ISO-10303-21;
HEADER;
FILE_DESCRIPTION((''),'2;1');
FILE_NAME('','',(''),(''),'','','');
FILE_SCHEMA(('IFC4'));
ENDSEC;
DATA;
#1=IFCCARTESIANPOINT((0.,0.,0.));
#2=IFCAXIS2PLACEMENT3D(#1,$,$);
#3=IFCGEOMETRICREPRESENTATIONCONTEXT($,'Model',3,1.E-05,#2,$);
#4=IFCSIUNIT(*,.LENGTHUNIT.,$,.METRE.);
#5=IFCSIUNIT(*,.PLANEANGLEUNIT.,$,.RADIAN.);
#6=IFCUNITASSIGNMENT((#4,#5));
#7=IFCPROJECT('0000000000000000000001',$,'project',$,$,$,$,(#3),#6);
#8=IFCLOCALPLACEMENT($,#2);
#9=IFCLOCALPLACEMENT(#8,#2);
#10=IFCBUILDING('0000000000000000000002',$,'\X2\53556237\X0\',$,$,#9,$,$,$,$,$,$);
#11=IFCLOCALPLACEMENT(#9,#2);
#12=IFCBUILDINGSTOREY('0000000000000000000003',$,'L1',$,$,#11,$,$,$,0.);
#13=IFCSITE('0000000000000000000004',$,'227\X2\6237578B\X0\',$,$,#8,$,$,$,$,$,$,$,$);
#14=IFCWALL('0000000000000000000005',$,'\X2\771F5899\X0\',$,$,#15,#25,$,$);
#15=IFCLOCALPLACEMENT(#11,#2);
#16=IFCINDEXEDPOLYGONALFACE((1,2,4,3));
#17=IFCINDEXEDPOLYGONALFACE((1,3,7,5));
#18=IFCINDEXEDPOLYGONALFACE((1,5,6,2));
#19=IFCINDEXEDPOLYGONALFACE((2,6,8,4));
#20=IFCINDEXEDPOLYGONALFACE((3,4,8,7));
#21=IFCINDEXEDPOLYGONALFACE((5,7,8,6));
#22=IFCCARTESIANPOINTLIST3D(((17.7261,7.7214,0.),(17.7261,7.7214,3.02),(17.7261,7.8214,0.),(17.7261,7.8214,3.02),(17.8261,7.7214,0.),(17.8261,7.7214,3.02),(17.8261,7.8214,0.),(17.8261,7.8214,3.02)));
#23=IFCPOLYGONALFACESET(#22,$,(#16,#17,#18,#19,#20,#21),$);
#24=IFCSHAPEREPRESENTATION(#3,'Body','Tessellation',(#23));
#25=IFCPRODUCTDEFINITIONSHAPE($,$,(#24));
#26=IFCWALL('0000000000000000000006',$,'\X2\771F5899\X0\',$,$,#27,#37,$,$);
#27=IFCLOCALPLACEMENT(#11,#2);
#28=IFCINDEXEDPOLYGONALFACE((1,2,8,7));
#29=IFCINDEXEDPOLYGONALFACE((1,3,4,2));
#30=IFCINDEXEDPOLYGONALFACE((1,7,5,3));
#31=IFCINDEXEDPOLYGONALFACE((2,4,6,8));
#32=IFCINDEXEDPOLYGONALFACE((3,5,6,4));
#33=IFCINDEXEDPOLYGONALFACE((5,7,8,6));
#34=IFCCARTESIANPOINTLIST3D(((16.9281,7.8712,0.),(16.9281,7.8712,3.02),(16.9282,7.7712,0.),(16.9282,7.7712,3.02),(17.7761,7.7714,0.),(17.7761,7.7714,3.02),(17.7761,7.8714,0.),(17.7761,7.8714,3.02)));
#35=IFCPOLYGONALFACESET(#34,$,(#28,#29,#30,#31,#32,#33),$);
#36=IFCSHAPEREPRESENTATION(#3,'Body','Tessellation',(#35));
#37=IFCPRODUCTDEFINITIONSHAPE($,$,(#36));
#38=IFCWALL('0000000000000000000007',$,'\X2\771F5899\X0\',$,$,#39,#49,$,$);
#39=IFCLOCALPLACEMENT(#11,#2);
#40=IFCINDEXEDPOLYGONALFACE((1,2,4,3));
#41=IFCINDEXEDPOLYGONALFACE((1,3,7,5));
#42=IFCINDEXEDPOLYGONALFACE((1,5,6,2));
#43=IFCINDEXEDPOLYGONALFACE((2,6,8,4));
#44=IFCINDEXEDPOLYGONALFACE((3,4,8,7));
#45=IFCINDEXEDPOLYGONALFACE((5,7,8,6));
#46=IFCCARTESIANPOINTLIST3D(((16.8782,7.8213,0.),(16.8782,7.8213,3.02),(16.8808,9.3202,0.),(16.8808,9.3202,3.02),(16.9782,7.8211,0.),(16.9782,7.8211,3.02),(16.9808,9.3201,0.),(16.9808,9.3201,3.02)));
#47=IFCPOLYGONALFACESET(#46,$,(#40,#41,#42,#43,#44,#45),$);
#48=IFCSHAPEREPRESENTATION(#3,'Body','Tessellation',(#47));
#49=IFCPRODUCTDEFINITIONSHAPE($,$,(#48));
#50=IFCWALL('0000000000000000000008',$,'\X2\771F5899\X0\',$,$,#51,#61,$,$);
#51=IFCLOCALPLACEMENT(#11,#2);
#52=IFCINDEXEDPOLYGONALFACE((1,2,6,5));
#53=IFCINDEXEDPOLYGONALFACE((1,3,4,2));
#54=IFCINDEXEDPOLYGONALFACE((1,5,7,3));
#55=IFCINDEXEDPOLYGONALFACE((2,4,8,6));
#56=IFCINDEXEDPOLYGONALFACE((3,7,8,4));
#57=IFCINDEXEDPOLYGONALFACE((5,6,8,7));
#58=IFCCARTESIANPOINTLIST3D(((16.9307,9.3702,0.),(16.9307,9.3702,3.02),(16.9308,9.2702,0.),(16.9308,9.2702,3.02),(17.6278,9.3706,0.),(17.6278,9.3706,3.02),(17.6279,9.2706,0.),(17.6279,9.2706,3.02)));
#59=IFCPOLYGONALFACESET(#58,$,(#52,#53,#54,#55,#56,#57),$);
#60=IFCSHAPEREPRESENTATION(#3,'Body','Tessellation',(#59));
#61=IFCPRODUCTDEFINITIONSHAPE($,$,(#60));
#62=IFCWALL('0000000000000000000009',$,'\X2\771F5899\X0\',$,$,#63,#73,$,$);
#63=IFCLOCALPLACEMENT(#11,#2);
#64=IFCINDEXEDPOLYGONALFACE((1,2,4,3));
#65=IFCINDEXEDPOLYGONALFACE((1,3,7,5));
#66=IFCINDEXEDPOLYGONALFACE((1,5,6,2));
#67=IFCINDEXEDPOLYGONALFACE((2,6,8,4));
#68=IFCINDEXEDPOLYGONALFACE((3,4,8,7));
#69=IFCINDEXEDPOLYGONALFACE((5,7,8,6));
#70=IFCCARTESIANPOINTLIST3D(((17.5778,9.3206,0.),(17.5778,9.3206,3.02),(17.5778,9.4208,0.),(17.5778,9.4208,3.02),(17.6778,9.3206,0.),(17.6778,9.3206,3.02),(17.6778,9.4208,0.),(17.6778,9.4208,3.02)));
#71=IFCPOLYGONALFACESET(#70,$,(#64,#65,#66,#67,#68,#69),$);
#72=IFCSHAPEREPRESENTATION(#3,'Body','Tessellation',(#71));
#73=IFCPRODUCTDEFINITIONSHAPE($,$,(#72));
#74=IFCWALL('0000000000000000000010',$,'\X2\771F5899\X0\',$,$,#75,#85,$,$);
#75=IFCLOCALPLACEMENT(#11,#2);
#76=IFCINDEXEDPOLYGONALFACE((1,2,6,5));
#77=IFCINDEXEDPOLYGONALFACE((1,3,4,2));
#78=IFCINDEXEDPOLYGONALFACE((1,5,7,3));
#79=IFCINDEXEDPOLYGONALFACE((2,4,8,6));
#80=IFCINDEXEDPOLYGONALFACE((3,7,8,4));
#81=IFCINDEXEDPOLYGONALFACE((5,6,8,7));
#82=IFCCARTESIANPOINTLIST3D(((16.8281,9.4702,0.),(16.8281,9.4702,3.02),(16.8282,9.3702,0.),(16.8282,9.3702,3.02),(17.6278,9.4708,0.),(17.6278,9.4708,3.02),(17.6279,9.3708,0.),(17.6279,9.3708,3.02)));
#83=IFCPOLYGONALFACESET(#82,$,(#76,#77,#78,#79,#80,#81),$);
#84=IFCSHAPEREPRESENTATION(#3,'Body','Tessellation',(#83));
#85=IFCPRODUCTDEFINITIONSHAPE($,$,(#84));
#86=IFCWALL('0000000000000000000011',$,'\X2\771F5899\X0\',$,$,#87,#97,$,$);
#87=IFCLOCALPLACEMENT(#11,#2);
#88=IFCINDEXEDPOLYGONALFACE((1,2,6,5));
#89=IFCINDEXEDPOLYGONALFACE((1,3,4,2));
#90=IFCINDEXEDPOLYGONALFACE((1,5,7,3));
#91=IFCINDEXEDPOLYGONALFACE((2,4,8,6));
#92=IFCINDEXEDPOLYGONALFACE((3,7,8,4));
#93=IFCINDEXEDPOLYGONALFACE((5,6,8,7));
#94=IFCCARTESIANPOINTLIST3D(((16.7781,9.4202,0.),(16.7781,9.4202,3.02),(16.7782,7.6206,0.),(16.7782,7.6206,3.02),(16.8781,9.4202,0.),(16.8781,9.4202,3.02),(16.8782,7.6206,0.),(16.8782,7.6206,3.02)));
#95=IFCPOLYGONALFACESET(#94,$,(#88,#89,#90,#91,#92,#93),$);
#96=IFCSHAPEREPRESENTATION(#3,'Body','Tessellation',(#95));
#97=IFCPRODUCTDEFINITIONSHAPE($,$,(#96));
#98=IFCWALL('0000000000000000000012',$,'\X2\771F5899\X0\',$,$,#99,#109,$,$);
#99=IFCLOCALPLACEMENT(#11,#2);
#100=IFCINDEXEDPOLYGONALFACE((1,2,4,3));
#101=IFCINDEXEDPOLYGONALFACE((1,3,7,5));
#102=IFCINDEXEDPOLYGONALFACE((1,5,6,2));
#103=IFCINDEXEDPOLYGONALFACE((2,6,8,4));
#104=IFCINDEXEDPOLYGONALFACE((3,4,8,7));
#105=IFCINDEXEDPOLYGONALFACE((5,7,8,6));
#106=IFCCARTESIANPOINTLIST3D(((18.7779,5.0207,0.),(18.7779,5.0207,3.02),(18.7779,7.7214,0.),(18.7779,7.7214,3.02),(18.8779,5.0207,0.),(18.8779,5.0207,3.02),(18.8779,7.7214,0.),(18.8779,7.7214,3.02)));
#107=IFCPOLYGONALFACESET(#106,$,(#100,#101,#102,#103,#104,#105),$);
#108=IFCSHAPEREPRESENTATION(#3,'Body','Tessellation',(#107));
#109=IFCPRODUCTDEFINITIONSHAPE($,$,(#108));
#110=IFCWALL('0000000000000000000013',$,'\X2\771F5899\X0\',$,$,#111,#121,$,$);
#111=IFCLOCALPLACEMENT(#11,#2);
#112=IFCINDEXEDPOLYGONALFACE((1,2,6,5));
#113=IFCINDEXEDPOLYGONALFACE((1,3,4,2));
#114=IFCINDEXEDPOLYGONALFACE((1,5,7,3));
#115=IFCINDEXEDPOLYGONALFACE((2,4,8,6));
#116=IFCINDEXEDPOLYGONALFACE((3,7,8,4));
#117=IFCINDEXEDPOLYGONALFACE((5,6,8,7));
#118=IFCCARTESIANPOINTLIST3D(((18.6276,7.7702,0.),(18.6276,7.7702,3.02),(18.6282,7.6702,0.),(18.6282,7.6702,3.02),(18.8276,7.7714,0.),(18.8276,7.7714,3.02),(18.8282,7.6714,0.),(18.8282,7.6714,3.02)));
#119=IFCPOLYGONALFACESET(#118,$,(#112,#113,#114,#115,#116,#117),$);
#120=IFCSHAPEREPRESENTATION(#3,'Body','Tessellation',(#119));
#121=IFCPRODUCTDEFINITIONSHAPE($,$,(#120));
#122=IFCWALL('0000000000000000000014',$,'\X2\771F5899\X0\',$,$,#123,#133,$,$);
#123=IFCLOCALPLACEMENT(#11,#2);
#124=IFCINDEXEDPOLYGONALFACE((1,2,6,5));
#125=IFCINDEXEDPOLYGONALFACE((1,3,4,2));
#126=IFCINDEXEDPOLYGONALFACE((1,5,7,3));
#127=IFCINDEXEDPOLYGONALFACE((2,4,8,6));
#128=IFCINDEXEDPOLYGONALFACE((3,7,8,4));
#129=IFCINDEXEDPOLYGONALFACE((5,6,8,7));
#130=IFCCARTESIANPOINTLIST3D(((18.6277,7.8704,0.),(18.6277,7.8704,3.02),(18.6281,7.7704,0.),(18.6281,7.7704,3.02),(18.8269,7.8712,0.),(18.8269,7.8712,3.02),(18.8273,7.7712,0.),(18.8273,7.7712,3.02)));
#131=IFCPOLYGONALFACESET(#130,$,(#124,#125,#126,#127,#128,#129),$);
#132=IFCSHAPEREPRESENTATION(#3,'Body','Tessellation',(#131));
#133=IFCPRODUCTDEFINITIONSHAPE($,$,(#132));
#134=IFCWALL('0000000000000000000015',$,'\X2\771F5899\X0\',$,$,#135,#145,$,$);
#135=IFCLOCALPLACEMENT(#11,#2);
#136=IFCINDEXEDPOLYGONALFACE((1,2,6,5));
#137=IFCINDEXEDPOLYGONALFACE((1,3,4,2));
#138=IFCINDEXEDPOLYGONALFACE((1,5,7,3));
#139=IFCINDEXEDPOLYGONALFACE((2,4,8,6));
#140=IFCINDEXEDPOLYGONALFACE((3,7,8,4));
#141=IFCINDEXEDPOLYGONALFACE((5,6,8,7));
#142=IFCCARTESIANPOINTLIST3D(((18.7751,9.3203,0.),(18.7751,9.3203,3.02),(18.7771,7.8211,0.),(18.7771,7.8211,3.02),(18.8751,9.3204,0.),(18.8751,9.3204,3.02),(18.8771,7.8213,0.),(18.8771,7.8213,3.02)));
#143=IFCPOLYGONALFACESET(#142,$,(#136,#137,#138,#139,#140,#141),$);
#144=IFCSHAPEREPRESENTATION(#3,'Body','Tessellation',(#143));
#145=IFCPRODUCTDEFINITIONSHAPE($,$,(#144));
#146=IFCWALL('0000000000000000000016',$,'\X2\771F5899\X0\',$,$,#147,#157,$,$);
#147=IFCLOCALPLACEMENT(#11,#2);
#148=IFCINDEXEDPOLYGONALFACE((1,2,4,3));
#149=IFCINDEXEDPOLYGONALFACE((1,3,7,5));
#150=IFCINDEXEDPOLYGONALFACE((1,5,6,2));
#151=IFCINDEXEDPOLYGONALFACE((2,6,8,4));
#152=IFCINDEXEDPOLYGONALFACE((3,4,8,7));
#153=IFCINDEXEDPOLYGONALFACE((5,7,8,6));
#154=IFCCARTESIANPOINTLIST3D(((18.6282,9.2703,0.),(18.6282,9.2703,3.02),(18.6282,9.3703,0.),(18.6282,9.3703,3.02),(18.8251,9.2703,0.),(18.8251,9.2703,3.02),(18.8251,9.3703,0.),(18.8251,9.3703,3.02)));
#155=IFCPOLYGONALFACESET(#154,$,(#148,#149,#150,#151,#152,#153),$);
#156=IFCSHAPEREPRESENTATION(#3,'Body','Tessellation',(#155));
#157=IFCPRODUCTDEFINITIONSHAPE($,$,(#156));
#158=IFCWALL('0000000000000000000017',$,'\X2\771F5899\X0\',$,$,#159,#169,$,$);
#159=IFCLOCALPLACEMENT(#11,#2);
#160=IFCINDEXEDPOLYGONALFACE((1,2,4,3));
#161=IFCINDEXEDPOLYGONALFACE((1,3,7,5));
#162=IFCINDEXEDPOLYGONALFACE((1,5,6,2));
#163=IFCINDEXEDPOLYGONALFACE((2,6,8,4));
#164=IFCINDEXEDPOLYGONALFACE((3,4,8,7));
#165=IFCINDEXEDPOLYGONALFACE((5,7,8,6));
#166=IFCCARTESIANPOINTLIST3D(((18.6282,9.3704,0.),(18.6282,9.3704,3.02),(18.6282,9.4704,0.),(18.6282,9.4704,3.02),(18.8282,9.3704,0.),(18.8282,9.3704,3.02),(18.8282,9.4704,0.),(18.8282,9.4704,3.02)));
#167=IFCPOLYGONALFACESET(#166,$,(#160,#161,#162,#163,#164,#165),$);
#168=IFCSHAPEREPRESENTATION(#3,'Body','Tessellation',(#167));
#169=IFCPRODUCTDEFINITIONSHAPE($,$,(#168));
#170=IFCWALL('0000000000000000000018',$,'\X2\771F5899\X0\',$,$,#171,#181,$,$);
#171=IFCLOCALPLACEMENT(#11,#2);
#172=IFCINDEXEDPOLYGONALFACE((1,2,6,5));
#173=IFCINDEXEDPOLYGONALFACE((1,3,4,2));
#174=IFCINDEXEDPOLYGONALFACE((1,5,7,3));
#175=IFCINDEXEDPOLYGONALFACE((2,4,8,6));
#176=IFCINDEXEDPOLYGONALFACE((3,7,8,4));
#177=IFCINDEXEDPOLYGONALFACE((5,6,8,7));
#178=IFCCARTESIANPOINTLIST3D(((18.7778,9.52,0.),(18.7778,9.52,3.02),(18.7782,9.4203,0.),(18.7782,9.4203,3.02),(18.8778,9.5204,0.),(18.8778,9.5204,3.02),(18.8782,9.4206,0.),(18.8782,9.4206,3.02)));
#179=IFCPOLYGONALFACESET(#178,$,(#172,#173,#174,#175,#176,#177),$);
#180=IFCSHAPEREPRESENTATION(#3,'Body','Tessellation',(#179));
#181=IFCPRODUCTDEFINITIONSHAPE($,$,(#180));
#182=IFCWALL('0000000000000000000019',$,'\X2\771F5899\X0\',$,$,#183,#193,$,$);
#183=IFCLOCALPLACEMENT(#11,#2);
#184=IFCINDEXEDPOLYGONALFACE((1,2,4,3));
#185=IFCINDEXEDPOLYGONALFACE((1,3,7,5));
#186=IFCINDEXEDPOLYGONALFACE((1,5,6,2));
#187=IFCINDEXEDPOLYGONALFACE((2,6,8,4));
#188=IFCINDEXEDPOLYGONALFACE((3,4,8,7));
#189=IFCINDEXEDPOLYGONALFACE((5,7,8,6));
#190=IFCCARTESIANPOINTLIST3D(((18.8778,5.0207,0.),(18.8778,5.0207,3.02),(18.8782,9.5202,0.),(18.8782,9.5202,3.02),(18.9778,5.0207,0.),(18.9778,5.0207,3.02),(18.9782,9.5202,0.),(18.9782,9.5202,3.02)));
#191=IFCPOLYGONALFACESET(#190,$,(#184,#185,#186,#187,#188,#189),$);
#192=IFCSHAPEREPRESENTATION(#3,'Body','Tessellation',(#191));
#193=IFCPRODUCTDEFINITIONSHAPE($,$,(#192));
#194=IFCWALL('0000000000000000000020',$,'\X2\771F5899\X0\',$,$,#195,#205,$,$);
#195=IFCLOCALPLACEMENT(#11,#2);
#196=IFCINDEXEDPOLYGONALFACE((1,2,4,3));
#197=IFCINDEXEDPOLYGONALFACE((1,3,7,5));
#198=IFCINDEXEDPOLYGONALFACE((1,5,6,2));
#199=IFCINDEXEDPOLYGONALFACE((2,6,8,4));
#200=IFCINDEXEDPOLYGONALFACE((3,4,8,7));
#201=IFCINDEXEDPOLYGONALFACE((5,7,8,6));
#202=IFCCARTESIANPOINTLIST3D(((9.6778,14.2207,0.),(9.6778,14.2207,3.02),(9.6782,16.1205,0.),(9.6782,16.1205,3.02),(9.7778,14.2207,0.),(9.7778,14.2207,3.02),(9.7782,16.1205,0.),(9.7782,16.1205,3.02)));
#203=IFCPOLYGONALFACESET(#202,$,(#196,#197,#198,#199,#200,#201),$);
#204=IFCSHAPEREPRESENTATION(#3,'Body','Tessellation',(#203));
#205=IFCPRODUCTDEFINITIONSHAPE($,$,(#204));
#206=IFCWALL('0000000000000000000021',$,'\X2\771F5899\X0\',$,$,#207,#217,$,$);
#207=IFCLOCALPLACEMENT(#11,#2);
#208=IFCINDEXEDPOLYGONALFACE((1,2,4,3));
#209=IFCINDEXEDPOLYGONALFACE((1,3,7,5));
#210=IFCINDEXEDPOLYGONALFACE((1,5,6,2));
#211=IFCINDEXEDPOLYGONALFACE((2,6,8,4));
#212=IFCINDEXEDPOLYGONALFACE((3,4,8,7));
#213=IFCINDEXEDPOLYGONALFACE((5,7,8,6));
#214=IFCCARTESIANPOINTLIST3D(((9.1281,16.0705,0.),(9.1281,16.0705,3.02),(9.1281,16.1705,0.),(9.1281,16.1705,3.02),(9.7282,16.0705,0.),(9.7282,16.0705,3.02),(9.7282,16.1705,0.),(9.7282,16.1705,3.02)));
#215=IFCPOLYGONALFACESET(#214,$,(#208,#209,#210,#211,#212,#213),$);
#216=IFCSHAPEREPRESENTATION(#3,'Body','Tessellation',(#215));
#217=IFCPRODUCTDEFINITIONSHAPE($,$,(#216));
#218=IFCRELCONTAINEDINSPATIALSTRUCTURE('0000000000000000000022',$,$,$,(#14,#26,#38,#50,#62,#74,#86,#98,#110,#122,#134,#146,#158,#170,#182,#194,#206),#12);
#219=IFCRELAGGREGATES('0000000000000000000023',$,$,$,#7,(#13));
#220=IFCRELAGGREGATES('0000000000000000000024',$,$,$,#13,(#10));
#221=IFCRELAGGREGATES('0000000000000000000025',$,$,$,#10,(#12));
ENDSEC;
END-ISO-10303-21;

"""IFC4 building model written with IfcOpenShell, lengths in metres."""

from ifc_helpers import new_model, si_unit, origin, place, context, project, spatial, polyline, outline, extrude, element, save


model = new_model("IFC4")

# Units and contexts
model_context = context("Model", 3, precision=1e-05, world=origin())
ifc_project = project(units=[si_unit("LENGTHUNIT", "METRE"), si_unit("PLANEANGLEUNIT", "RADIAN")], contexts=[model_context])

# Site, building, storey
site_placement = place(None, origin())
site = spatial("IfcSite", under=ifc_project, at=site_placement, Name="227户型")
building_placement = place(site_placement, origin())
building = spatial("IfcBuilding", under=site, at=building_placement, Name="单户")
storey_placement = place(building_placement, origin())
storey = spatial("IfcBuildingStorey", under=building, at=storey_placement, Name="L1", Elevation=0.0)

# Walls
wall_1_placement = place(storey_placement, origin())
element("IfcWall", 1, at=wall_1_placement, inside=storey, Name="真墙", context=model_context, shape_type="SweptSolid", body=[
    extrude(outline(polyline([(17.7261, 7.7214), (17.7261, 7.8214), (17.8261, 7.8214), (17.8261, 7.7214), (17.7261, 7.7214)])), origin(), (0.0, 0.0, 1.0), 3.02),
])
wall_2_placement = place(storey_placement, origin())
element("IfcWall", 2, at=wall_2_placement, inside=storey, Name="真墙", context=model_context, shape_type="SweptSolid", body=[
    extrude(outline(polyline([(17.7761, 7.7714), (16.9282, 7.7712), (16.9281, 7.8712), (17.7761, 7.8714), (17.7761, 7.7714)])), origin(), (0.0, 0.0, 1.0), 3.02),
])
wall_3_placement = place(storey_placement, origin())
element("IfcWall", 3, at=wall_3_placement, inside=storey, Name="真墙", context=model_context, shape_type="SweptSolid", body=[
    extrude(outline(polyline([(16.8782, 7.8213), (16.8808, 9.3202), (16.9808, 9.3201), (16.9782, 7.8211), (16.8782, 7.8213)])), origin(), (0.0, 0.0, 1.0), 3.02),
])
wall_4_placement = place(storey_placement, origin())
element("IfcWall", 4, at=wall_4_placement, inside=storey, Name="真墙", context=model_context, shape_type="SweptSolid", body=[
    extrude(outline(polyline([(16.9307, 9.3702), (17.6278, 9.3706), (17.6279, 9.2706), (16.9308, 9.2702), (16.9307, 9.3702)])), origin(), (0.0, 0.0, 1.0), 3.02),
])
wall_5_placement = place(storey_placement, origin())
element("IfcWall", 5, at=wall_5_placement, inside=storey, Name="真墙", context=model_context, shape_type="SweptSolid", body=[
    extrude(outline(polyline([(17.5778, 9.3206), (17.5778, 9.4208), (17.6778, 9.4208), (17.6778, 9.3206), (17.5778, 9.3206)])), origin(), (0.0, 0.0, 1.0), 3.02),
])
wall_6_placement = place(storey_placement, origin())
element("IfcWall", 6, at=wall_6_placement, inside=storey, Name="真墙", context=model_context, shape_type="SweptSolid", body=[
    extrude(outline(polyline([(17.6279, 9.3708), (16.8282, 9.3702), (16.8281, 9.4702), (17.6278, 9.4708), (17.6279, 9.3708)])), origin(), (0.0, 0.0, 1.0), 3.02),
])
wall_7_placement = place(storey_placement, origin())
element("IfcWall", 7, at=wall_7_placement, inside=storey, Name="真墙", context=model_context, shape_type="SweptSolid", body=[
    extrude(outline(polyline([(16.8781, 9.4202), (16.8782, 7.6206), (16.7782, 7.6206), (16.7781, 9.4202), (16.8781, 9.4202)])), origin(), (0.0, 0.0, 1.0), 3.02),
])
wall_8_placement = place(storey_placement, origin())
element("IfcWall", 8, at=wall_8_placement, inside=storey, Name="真墙", context=model_context, shape_type="SweptSolid", body=[
    extrude(outline(polyline([(18.7779, 5.0207), (18.7779, 7.7214), (18.8779, 7.7214), (18.8779, 5.0207), (18.7779, 5.0207)])), origin(), (0.0, 0.0, 1.0), 3.02),
])
wall_9_placement = place(storey_placement, origin())
element("IfcWall", 9, at=wall_9_placement, inside=storey, Name="真墙", context=model_context, shape_type="SweptSolid", body=[
    extrude(outline(polyline([(18.8282, 7.6714), (18.6282, 7.6702), (18.6276, 7.7702), (18.8276, 7.7714), (18.8282, 7.6714)])), origin(), (0.0, 0.0, 1.0), 3.02),
])

# Walls
wall_10_placement = place(storey_placement, origin())
element("IfcWall", 10, at=wall_10_placement, inside=storey, Name="真墙", context=model_context, shape_type="SweptSolid", body=[
    extrude(outline(polyline([(18.6277, 7.8704), (18.8269, 7.8712), (18.8273, 7.7712), (18.6281, 7.7704), (18.6277, 7.8704)])), origin(), (0.0, 0.0, 1.0), 3.02),
])
wall_11_placement = place(storey_placement, origin())
element("IfcWall", 11, at=wall_11_placement, inside=storey, Name="真墙", context=model_context, shape_type="SweptSolid", body=[
    extrude(outline(polyline([(18.7771, 7.8211), (18.7751, 9.3203), (18.8751, 9.3204), (18.8771, 7.8213), (18.7771, 7.8211)])), origin(), (0.0, 0.0, 1.0), 3.02),
])
wall_12_placement = place(storey_placement, origin())
element("IfcWall", 12, at=wall_12_placement, inside=storey, Name="真墙", context=model_context, shape_type="SweptSolid", body=[
    extrude(outline(polyline([(18.8251, 9.2703), (18.6282, 9.2703), (18.6282, 9.3703), (18.8251, 9.3703), (18.8251, 9.2703)])), origin(), (0.0, 0.0, 1.0), 3.02),
])

# Walls
wall_13_placement = place(storey_placement, origin())
element("IfcWall", 13, at=wall_13_placement, inside=storey, Name="真墙", context=model_context, shape_type="SweptSolid", body=[
    extrude(outline(polyline([(18.6282, 9.4704), (18.8282, 9.4704), (18.8282, 9.3704), (18.6282, 9.3704), (18.6282, 9.4704)])), origin(), (0.0, 0.0, 1.0), 3.02),
])
wall_14_placement = place(storey_placement, origin())
element("IfcWall", 14, at=wall_14_placement, inside=storey, Name="真墙", context=model_context, shape_type="SweptSolid", body=[
    extrude(outline(polyline([(18.7782, 9.4203), (18.7778, 9.52), (18.8778, 9.5204), (18.8782, 9.4206), (18.7782, 9.4203)])), origin(), (0.0, 0.0, 1.0), 3.02),
])

# Walls
wall_15_placement = place(storey_placement, origin())
element("IfcWall", 15, at=wall_15_placement, inside=storey, Name="真墙", context=model_context, shape_type="SweptSolid", body=[
    extrude(outline(polyline([(18.9782, 9.5202), (18.9778, 5.0207), (18.8778, 5.0207), (18.8782, 9.5202), (18.9782, 9.5202)])), origin(), (0.0, 0.0, 1.0), 3.02),
])
wall_16_placement = place(storey_placement, origin())
element("IfcWall", 16, at=wall_16_placement, inside=storey, Name="真墙", context=model_context, shape_type="SweptSolid", body=[
    extrude(outline(polyline([(9.6778, 14.2207), (9.6782, 16.1205), (9.7782, 16.1205), (9.7778, 14.2207), (9.6778, 14.2207)])), origin(), (0.0, 0.0, 1.0), 3.02),
])
wall_17_placement = place(storey_placement, origin())
element("IfcWall", 17, at=wall_17_placement, inside=storey, Name="真墙", context=model_context, shape_type="SweptSolid", body=[
    extrude(outline(polyline([(9.7282, 16.0705), (9.1281, 16.0705), (9.1281, 16.1705), (9.7282, 16.1705), (9.7282, 16.0705)])), origin(), (0.0, 0.0, 1.0), 3.02),
])

save(model, "model.ifc")
